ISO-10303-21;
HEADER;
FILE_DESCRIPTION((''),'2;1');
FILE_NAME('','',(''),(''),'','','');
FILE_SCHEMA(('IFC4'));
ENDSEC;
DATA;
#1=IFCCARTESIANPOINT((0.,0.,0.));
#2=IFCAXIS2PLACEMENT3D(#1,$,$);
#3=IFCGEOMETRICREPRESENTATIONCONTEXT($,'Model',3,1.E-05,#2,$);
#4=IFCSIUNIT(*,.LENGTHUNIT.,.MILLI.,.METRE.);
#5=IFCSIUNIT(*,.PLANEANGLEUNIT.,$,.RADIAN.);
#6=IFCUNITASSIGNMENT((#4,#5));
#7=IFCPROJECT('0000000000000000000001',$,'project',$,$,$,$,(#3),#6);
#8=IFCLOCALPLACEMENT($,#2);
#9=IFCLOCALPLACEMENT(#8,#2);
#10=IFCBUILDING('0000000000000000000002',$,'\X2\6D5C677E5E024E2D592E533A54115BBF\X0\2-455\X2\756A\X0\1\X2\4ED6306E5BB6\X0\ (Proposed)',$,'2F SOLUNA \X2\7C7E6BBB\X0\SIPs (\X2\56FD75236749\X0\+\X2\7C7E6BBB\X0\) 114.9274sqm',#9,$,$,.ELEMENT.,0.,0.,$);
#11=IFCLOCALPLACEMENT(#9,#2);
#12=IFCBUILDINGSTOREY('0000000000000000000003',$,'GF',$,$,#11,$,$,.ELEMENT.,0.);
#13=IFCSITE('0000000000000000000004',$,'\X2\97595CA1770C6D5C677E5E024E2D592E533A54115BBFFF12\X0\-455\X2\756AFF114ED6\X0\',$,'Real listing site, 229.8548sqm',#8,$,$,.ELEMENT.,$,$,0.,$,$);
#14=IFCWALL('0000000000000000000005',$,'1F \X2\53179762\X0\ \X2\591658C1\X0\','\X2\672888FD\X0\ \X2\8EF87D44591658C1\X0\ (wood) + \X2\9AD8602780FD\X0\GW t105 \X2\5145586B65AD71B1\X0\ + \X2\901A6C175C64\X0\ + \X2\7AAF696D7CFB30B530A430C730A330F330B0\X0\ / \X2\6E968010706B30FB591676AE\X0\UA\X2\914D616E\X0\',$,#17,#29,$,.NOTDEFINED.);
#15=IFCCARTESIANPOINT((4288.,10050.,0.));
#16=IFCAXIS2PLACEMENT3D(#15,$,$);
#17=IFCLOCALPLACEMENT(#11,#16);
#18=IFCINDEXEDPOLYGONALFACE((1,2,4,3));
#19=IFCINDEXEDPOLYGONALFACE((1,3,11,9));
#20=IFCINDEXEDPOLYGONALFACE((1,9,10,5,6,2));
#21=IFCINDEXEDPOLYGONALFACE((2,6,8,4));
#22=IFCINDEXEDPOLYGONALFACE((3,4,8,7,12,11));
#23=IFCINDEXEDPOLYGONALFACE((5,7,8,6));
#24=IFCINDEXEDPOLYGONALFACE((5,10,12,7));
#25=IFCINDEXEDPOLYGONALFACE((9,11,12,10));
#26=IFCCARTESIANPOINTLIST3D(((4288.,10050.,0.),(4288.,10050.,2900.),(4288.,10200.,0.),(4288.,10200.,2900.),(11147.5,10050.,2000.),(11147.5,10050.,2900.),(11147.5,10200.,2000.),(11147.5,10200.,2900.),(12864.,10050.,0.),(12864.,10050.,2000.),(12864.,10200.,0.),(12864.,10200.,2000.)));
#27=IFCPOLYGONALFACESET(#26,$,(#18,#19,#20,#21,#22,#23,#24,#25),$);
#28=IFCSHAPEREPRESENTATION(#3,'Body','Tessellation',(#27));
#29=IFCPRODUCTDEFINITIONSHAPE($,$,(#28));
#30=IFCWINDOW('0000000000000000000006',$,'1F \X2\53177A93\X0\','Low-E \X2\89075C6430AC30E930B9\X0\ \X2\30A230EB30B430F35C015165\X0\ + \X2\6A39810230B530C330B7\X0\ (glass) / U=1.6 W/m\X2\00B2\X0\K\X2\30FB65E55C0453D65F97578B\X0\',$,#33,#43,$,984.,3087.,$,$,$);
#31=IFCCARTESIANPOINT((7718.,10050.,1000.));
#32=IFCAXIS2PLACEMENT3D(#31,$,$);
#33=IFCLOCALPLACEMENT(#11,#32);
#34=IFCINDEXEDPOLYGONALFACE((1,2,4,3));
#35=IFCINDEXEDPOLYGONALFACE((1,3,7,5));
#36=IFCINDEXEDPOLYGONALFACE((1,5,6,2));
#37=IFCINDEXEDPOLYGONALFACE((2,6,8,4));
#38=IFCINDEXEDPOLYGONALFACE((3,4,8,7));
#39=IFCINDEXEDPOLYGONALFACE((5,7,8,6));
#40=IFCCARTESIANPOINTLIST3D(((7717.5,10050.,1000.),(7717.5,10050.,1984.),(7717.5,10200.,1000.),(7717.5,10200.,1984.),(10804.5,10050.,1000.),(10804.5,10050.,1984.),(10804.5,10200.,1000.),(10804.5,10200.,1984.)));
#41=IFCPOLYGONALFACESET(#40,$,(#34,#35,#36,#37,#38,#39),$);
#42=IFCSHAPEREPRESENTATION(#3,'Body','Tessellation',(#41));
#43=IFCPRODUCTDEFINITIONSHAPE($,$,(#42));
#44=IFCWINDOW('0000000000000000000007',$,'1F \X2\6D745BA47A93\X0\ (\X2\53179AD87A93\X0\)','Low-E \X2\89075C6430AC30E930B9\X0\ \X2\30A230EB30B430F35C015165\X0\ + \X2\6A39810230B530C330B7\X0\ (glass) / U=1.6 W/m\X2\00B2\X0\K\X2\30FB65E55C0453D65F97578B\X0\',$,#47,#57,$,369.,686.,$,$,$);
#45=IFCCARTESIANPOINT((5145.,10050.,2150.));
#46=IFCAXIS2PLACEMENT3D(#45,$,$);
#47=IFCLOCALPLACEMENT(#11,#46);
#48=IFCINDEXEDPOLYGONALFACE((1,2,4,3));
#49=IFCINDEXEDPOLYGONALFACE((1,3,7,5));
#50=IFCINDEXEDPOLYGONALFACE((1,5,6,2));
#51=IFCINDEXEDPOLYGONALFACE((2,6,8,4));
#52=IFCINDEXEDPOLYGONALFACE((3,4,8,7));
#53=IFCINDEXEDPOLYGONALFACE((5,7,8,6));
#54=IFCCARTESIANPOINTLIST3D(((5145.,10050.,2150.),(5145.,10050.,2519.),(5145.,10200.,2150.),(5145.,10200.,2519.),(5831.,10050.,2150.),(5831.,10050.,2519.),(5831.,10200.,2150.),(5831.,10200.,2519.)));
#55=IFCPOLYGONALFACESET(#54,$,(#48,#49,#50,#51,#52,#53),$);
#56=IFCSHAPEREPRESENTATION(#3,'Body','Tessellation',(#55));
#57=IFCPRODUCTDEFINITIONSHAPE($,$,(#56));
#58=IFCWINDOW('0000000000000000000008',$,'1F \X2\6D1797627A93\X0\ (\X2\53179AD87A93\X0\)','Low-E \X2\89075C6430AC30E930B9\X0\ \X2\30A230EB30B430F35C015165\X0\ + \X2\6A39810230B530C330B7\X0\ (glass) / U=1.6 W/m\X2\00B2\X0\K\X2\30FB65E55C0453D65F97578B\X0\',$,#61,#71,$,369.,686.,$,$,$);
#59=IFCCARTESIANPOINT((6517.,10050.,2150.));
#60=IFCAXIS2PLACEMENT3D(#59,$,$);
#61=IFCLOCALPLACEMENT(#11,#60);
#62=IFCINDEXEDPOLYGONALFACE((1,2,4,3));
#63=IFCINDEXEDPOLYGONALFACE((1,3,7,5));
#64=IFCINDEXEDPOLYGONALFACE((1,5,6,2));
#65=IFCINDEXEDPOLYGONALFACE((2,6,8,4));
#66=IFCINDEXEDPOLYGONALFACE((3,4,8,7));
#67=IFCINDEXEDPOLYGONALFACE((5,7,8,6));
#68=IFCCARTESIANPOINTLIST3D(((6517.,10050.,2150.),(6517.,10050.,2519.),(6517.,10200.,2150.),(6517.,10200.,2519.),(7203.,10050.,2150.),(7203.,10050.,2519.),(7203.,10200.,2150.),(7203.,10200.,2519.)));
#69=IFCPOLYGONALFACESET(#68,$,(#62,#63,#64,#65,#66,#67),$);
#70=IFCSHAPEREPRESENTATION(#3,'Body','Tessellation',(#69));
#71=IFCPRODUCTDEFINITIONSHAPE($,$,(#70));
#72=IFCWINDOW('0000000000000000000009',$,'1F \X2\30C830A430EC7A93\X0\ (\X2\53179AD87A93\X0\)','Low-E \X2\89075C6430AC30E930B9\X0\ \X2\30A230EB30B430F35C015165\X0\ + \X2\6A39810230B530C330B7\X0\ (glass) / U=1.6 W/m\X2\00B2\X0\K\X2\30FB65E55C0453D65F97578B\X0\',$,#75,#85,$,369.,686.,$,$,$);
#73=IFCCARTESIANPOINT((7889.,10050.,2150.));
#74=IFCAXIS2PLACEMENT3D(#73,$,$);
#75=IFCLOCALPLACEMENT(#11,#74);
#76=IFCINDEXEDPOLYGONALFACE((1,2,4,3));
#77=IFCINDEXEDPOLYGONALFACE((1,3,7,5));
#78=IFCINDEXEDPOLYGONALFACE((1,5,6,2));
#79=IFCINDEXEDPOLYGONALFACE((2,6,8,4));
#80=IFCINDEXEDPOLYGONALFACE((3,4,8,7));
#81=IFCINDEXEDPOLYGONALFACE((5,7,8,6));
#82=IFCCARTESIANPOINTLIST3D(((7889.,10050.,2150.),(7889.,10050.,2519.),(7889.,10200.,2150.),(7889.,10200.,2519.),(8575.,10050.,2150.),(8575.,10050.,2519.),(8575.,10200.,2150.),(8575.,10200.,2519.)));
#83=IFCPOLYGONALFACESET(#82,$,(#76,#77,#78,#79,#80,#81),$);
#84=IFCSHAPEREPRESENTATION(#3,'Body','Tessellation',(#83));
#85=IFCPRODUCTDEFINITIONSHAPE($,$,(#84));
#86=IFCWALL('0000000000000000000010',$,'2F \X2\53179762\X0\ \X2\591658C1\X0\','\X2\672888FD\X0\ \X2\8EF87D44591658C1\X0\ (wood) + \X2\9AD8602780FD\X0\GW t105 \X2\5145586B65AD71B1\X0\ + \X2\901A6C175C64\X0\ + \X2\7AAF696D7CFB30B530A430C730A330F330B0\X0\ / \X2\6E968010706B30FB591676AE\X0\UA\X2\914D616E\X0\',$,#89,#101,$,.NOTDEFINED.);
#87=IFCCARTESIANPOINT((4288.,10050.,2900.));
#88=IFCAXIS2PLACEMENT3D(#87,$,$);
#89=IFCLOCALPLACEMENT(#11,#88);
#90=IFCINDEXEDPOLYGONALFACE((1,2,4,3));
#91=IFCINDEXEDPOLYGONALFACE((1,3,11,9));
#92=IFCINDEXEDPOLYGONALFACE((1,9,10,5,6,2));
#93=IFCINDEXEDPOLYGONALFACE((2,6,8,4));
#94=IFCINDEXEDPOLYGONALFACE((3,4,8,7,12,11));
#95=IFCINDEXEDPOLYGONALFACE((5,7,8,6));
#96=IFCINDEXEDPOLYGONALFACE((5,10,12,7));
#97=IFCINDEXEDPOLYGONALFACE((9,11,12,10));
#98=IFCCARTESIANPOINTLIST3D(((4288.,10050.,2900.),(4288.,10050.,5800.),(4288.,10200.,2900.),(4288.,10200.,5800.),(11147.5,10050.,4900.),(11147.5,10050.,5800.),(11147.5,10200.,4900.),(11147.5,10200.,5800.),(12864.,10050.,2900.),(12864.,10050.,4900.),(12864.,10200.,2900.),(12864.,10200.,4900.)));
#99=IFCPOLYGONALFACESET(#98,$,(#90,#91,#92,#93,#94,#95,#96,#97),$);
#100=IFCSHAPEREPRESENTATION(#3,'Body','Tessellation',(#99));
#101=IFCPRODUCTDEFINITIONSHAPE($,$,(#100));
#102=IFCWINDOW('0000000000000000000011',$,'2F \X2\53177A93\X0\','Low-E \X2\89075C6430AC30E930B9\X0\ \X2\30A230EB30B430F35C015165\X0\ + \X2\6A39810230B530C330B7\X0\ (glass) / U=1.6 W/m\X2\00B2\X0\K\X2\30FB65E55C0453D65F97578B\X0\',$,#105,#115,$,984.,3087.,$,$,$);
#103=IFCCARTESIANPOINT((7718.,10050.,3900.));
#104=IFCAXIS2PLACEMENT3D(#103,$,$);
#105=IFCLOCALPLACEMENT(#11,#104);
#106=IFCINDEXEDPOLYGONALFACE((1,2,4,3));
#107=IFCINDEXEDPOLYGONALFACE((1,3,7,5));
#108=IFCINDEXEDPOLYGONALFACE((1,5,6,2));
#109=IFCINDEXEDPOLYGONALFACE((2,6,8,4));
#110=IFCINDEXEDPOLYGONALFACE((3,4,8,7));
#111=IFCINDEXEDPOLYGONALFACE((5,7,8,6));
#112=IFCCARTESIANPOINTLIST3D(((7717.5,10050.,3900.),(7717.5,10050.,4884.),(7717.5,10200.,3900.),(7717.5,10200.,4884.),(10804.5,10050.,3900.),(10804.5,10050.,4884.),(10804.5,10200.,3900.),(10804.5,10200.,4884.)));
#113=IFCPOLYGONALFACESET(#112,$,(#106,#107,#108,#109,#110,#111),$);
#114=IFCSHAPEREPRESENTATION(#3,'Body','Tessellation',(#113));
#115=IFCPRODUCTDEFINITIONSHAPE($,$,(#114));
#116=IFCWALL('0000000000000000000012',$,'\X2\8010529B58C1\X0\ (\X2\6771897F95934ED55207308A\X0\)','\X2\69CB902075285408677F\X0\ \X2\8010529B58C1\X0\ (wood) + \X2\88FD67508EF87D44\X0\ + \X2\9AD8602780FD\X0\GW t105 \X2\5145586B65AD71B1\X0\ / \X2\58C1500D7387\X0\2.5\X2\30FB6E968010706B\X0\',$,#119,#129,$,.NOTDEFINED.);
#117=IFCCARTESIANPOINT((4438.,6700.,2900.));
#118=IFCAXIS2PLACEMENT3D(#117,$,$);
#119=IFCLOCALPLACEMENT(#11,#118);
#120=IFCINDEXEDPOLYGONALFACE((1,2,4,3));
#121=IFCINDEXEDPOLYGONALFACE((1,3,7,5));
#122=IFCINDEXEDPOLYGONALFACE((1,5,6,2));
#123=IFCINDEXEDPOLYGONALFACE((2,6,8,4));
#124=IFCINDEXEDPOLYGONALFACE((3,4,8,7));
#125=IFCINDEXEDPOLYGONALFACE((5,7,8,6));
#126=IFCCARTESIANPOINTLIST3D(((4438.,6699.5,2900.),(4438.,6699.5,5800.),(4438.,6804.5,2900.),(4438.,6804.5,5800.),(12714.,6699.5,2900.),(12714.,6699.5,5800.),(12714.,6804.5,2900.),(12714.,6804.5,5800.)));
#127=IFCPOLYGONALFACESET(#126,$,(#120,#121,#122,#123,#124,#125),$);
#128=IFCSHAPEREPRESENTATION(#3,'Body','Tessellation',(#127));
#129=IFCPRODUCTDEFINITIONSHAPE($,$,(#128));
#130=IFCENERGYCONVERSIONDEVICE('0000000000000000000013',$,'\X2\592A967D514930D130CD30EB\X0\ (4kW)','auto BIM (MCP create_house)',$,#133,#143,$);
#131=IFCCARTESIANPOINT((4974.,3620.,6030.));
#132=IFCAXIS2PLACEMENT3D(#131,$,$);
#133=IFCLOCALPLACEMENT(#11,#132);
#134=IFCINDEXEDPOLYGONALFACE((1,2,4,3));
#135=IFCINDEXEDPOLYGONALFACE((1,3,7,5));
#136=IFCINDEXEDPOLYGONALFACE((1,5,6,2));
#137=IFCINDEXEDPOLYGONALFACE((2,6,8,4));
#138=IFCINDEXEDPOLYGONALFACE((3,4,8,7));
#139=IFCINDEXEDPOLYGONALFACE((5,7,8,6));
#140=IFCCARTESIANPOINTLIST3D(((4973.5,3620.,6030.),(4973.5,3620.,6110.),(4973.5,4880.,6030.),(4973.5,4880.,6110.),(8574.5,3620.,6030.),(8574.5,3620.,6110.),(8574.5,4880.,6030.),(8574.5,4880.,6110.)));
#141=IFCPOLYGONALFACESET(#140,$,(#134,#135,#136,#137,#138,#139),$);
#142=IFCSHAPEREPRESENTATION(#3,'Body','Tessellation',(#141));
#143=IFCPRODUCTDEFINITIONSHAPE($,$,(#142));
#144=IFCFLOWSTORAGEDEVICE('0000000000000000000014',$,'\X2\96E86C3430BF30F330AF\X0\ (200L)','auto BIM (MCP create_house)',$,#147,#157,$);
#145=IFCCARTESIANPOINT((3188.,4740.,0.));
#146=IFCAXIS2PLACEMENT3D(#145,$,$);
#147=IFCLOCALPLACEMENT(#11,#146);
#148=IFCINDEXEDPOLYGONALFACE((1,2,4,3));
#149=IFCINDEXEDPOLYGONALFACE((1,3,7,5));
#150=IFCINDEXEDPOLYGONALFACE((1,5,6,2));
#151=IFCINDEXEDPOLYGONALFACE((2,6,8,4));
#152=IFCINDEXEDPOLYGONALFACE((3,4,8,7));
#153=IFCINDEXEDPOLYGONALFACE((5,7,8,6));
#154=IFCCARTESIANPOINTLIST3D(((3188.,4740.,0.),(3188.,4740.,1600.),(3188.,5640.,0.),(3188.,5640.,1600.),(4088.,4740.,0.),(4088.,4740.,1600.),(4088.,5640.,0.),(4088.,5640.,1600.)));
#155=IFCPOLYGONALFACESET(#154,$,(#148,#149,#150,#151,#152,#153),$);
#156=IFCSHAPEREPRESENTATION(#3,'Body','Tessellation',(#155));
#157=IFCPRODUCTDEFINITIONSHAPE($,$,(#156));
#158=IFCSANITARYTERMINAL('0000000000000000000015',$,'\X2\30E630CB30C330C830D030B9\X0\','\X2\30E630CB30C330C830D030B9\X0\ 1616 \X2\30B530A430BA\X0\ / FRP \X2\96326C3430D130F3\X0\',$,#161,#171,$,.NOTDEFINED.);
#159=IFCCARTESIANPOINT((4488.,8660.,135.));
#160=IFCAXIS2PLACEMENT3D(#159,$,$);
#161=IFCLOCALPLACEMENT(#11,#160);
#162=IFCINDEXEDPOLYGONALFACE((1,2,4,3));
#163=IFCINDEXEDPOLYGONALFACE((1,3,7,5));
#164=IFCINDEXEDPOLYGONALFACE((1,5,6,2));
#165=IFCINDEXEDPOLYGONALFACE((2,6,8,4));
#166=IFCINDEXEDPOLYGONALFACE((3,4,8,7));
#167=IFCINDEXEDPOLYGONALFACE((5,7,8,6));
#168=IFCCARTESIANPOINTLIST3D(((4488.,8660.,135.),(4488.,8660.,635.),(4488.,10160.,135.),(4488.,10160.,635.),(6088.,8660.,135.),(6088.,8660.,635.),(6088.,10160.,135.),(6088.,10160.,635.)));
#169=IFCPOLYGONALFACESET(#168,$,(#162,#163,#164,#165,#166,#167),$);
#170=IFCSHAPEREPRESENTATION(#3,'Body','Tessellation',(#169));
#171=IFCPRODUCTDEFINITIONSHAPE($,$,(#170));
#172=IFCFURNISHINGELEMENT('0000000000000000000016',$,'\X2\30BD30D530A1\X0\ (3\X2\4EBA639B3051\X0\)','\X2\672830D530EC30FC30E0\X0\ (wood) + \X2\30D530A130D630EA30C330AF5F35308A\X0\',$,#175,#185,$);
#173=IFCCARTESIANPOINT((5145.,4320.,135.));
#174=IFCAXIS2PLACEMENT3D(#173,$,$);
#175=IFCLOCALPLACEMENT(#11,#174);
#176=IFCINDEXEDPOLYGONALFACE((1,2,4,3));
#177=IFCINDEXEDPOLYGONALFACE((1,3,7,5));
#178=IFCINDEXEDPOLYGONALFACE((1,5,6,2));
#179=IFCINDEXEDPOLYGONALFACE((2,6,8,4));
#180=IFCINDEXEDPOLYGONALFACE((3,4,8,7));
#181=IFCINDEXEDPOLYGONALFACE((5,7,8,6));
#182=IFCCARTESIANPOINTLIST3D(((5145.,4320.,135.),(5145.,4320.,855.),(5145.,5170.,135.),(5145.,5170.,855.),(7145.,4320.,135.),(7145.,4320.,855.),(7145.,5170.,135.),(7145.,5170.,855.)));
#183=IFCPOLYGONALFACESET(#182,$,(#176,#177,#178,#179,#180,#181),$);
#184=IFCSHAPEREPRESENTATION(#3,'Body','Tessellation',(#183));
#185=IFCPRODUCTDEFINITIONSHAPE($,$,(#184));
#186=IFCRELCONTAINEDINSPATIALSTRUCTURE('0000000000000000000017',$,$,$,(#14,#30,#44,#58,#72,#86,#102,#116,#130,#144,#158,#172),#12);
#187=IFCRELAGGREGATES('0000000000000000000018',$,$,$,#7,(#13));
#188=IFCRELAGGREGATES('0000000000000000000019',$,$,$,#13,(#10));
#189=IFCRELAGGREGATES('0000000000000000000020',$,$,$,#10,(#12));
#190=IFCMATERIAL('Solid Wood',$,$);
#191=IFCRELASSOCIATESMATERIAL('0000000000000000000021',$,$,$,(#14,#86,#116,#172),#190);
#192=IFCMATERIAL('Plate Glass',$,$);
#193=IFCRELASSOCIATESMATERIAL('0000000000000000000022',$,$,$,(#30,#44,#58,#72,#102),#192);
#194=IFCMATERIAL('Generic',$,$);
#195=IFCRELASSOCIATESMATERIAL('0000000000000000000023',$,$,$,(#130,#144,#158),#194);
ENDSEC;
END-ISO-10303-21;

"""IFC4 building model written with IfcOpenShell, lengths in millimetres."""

from ifc_helpers import new_model, si_unit, frame, frame_2d, origin, place, context, project, spatial, rectangle, extrude, material, element, fill, save


model = new_model("IFC4")

# Units and contexts
model_context = context("Model", 3, precision=1e-05, world=origin())
ifc_project = project(units=[si_unit("LENGTHUNIT", "METRE", prefix="MILLI"), si_unit("PLANEANGLEUNIT", "RADIAN")], contexts=[model_context])

# Site, building, storey
site_placement = place(None, origin())
site = spatial("IfcSite", under=ifc_project, at=site_placement, Name="静岡県浜松市中央区向宿２-455番１他", ObjectType="Real listing site, 229.8548sqm", CompositionType="ELEMENT", RefElevation=0.0)
building_placement = place(site_placement, origin())
building = spatial("IfcBuilding", under=site, at=building_placement, Name="浜松市中央区向宿2-455番1他の家 (Proposed)", ObjectType="2F SOLUNA 籾殻SIPs (国産杉+籾殻) 114.9274sqm", CompositionType="ELEMENT", ElevationOfRefHeight=0.0, ElevationOfTerrain=0.0)
storey_placement = place(building_placement, origin())
storey = spatial("IfcBuildingStorey", under=building, at=storey_placement, Name="GF", CompositionType="ELEMENT", Elevation=0.0)

# Wall, openings, windows
ifc_material_1 = material(Name="Solid Wood")
wall_1_placement = place(storey_placement, frame((4288.0, 10050.0, 0.0)))
wall_1 = element("IfcWall", 1, at=wall_1_placement, inside=storey, material=ifc_material_1, Name="1F 北面 外壁", Description="木製 軸組外壁 (wood) + 高性能GW t105 充填断熱 + 通気層 + 窯業系サイディング / 準耐火・外皮UA配慮", PredefinedType="NOTDEFINED", context=model_context, shape_type="SweptSolid", body=[
    extrude(rectangle(XDim=8576.0, YDim=150.0, at=frame_2d((4288.0, 75.0))), frame((4288.0, 10050.0, 0.0)), (0.0, 0.0, 1.0), 2900.0),
])
opening_1_placement = place(storey_placement, frame((7718.0, 10050.0, 1000.0)))
opening_1 = element("IfcOpeningElement", 2, at=opening_1_placement, cuts=wall_1, PredefinedType="NOTDEFINED", context=model_context, shape_type="SweptSolid", body=[
    extrude(rectangle(XDim=3087.0, YDim=150.0, at=frame_2d((1543.0, 75.0))), frame((7718.0, 10050.0, 1000.0)), (0.0, 0.0, 1.0), 984.0),
])
opening_2_placement = place(storey_placement, frame((5145.0, 10050.0, 2150.0)))
opening_2 = element("IfcOpeningElement", 3, at=opening_2_placement, cuts=wall_1, PredefinedType="NOTDEFINED", context=model_context, shape_type="SweptSolid", body=[
    extrude(rectangle(XDim=686.0, YDim=150.0, at=frame_2d((343.0, 75.0))), frame((5145.0, 10050.0, 2150.0)), (0.0, 0.0, 1.0), 369.0),
])
opening_3_placement = place(storey_placement, frame((6517.0, 10050.0, 2150.0)))
opening_3 = element("IfcOpeningElement", 4, at=opening_3_placement, cuts=wall_1, PredefinedType="NOTDEFINED", context=model_context, shape_type="SweptSolid", body=[
    extrude(rectangle(XDim=686.0, YDim=150.0, at=frame_2d((343.0, 75.0))), frame((6517.0, 10050.0, 2150.0)), (0.0, 0.0, 1.0), 369.0),
])
opening_4_placement = place(storey_placement, frame((7889.0, 10050.0, 2150.0)))
opening_4 = element("IfcOpeningElement", 5, at=opening_4_placement, cuts=wall_1, PredefinedType="NOTDEFINED", context=model_context, shape_type="SweptSolid", body=[
    extrude(rectangle(XDim=686.0, YDim=150.0, at=frame_2d((343.0, 75.0))), frame((7889.0, 10050.0, 2150.0)), (0.0, 0.0, 1.0), 369.0),
])
ifc_material_2 = material(Name="Plate Glass")
window_1_placement = place(storey_placement, frame((7718.0, 10050.0, 1000.0)))
window_1 = element("IfcWindow", 6, at=window_1_placement, inside=storey, material=ifc_material_2, Name="1F 北窓", Description="Low-E 複層ガラス アルゴン封入 + 樹脂サッシ (glass) / U=1.6 W/m²K・日射取得型", OverallHeight=984.0, OverallWidth=3087.0, context=model_context, shape_type="SweptSolid", body=[
    extrude(rectangle(XDim=3087.0, YDim=150.0, at=frame_2d((1543.0, 75.0))), frame((7718.0, 10050.0, 1000.0)), (0.0, 0.0, 1.0), 984.0),
])
fill(opening_1, window_1)
window_2_placement = place(storey_placement, frame((5145.0, 10050.0, 2150.0)))
window_2 = element("IfcWindow", 7, at=window_2_placement, inside=storey, material=ifc_material_2, Name="1F 浴室窓 (北高窓)", Description="Low-E 複層ガラス アルゴン封入 + 樹脂サッシ (glass) / U=1.6 W/m²K・日射取得型", OverallHeight=369.0, OverallWidth=686.0, context=model_context, shape_type="SweptSolid", body=[
    extrude(rectangle(XDim=686.0, YDim=150.0, at=frame_2d((343.0, 75.0))), frame((5145.0, 10050.0, 2150.0)), (0.0, 0.0, 1.0), 369.0),
])
fill(opening_2, window_2)
window_3_placement = place(storey_placement, frame((6517.0, 10050.0, 2150.0)))
window_3 = element("IfcWindow", 8, at=window_3_placement, inside=storey, material=ifc_material_2, Name="1F 洗面窓 (北高窓)", Description="Low-E 複層ガラス アルゴン封入 + 樹脂サッシ (glass) / U=1.6 W/m²K・日射取得型", OverallHeight=369.0, OverallWidth=686.0, context=model_context, shape_type="SweptSolid", body=[
    extrude(rectangle(XDim=686.0, YDim=150.0, at=frame_2d((343.0, 75.0))), frame((6517.0, 10050.0, 2150.0)), (0.0, 0.0, 1.0), 369.0),
])
fill(opening_3, window_3)
window_4_placement = place(storey_placement, frame((7889.0, 10050.0, 2150.0)))
window_4 = element("IfcWindow", 9, at=window_4_placement, inside=storey, material=ifc_material_2, Name="1F トイレ窓 (北高窓)", Description="Low-E 複層ガラス アルゴン封入 + 樹脂サッシ (glass) / U=1.6 W/m²K・日射取得型", OverallHeight=369.0, OverallWidth=686.0, context=model_context, shape_type="SweptSolid", body=[
    extrude(rectangle(XDim=686.0, YDim=150.0, at=frame_2d((343.0, 75.0))), frame((7889.0, 10050.0, 2150.0)), (0.0, 0.0, 1.0), 369.0),
])
fill(opening_4, window_4)

# Wall, opening, window
wall_2_placement = place(storey_placement, frame((4288.0, 10050.0, 2900.0)))
wall_2 = element("IfcWall", 10, at=wall_2_placement, inside=storey, material=ifc_material_1, Name="2F 北面 外壁", Description="木製 軸組外壁 (wood) + 高性能GW t105 充填断熱 + 通気層 + 窯業系サイディング / 準耐火・外皮UA配慮", PredefinedType="NOTDEFINED", context=model_context, shape_type="SweptSolid", body=[
    extrude(rectangle(XDim=8576.0, YDim=150.0, at=frame_2d((4288.0, 75.0))), frame((4288.0, 10050.0, 2900.0)), (0.0, 0.0, 1.0), 2900.0),
])
opening_5_placement = place(storey_placement, frame((7718.0, 10050.0, 3900.0)))
opening_5 = element("IfcOpeningElement", 11, at=opening_5_placement, cuts=wall_2, PredefinedType="NOTDEFINED", context=model_context, shape_type="SweptSolid", body=[
    extrude(rectangle(XDim=3087.0, YDim=150.0, at=frame_2d((1543.0, 75.0))), frame((7718.0, 10050.0, 3900.0)), (0.0, 0.0, 1.0), 984.0),
])
window_5_placement = place(storey_placement, frame((7718.0, 10050.0, 3900.0)))
window_5 = element("IfcWindow", 12, at=window_5_placement, inside=storey, material=ifc_material_2, Name="2F 北窓", Description="Low-E 複層ガラス アルゴン封入 + 樹脂サッシ (glass) / U=1.6 W/m²K・日射取得型", OverallHeight=984.0, OverallWidth=3087.0, context=model_context, shape_type="SweptSolid", body=[
    extrude(rectangle(XDim=3087.0, YDim=150.0, at=frame_2d((1543.0, 75.0))), frame((7718.0, 10050.0, 3900.0)), (0.0, 0.0, 1.0), 984.0),
])
fill(opening_5, window_5)

# Wall
wall_3_placement = place(storey_placement, frame((4438.0, 6700.0, 2900.0)))
element("IfcWall", 13, at=wall_3_placement, inside=storey, material=ifc_material_1, Name="耐力壁 (東西間仕切り)", Description="構造用合板 耐力壁 (wood) + 製材軸組 + 高性能GW t105 充填断熱 / 壁倍率2.5・準耐火", PredefinedType="NOTDEFINED", context=model_context, shape_type="SweptSolid", body=[
    extrude(rectangle(XDim=8276.0, YDim=105.0, at=frame_2d((4138.0, 52.0))), frame((4438.0, 6700.0, 2900.0)), (0.0, 0.0, 1.0), 2900.0),
])

# Energy conversion device
ifc_material_3 = material(Name="Generic")
energy_conversion_device_placement = place(storey_placement, frame((4974.0, 3620.0, 6030.0)))
element("IfcEnergyConversionDevice", 14, at=energy_conversion_device_placement, inside=storey, material=ifc_material_3, Name="太陽光パネル (4kW)", Description="auto BIM (MCP create_house)", context=model_context, shape_type="SweptSolid", body=[
    extrude(rectangle(XDim=3601.0, YDim=1260.0, at=frame_2d((1800.0, 630.0))), frame((4974.0, 3620.0, 6030.0)), (0.0, 0.0, 1.0), 80.0),
])

# Flow storage device
flow_storage_device_placement = place(storey_placement, frame((3188.0, 4740.0, 0.0)))
element("IfcFlowStorageDevice", 15, at=flow_storage_device_placement, inside=storey, material=ifc_material_3, Name="雨水タンク (200L)", Description="auto BIM (MCP create_house)", context=model_context, shape_type="SweptSolid", body=[
    extrude(rectangle(XDim=900.0, YDim=900.0, at=frame_2d((450.0, 450.0))), frame((3188.0, 4740.0, 0.0)), (0.0, 0.0, 1.0), 1600.0),
])

# Sanitary terminal
sanitary_terminal_placement = place(storey_placement, frame((4488.0, 8660.0, 135.0)))
element("IfcSanitaryTerminal", 16, at=sanitary_terminal_placement, inside=storey, material=ifc_material_3, Name="ユニットバス", Description="ユニットバス 1616 サイズ / FRP 防水パン", PredefinedType="NOTDEFINED", context=model_context, shape_type="SweptSolid", body=[
    extrude(rectangle(XDim=1600.0, YDim=1500.0, at=frame_2d((800.0, 750.0))), frame((4488.0, 8660.0, 135.0)), (0.0, 0.0, 1.0), 500.0),
])

# Furnishing element
furnishing_1_placement = place(storey_placement, frame((5145.0, 4320.0, 135.0)))
element("IfcFurnishingElement", 17, at=furnishing_1_placement, inside=storey, material=ifc_material_1, Name="ソファ (3人掛け)", Description="木フレーム (wood) + ファブリック張り", context=model_context, shape_type="SweptSolid", body=[
    extrude(rectangle(XDim=2000.0, YDim=850.0, at=frame_2d((1000.0, 425.0))), frame((5145.0, 4320.0, 135.0)), (0.0, 0.0, 1.0), 720.0),
])

save(model, "model.ifc")
